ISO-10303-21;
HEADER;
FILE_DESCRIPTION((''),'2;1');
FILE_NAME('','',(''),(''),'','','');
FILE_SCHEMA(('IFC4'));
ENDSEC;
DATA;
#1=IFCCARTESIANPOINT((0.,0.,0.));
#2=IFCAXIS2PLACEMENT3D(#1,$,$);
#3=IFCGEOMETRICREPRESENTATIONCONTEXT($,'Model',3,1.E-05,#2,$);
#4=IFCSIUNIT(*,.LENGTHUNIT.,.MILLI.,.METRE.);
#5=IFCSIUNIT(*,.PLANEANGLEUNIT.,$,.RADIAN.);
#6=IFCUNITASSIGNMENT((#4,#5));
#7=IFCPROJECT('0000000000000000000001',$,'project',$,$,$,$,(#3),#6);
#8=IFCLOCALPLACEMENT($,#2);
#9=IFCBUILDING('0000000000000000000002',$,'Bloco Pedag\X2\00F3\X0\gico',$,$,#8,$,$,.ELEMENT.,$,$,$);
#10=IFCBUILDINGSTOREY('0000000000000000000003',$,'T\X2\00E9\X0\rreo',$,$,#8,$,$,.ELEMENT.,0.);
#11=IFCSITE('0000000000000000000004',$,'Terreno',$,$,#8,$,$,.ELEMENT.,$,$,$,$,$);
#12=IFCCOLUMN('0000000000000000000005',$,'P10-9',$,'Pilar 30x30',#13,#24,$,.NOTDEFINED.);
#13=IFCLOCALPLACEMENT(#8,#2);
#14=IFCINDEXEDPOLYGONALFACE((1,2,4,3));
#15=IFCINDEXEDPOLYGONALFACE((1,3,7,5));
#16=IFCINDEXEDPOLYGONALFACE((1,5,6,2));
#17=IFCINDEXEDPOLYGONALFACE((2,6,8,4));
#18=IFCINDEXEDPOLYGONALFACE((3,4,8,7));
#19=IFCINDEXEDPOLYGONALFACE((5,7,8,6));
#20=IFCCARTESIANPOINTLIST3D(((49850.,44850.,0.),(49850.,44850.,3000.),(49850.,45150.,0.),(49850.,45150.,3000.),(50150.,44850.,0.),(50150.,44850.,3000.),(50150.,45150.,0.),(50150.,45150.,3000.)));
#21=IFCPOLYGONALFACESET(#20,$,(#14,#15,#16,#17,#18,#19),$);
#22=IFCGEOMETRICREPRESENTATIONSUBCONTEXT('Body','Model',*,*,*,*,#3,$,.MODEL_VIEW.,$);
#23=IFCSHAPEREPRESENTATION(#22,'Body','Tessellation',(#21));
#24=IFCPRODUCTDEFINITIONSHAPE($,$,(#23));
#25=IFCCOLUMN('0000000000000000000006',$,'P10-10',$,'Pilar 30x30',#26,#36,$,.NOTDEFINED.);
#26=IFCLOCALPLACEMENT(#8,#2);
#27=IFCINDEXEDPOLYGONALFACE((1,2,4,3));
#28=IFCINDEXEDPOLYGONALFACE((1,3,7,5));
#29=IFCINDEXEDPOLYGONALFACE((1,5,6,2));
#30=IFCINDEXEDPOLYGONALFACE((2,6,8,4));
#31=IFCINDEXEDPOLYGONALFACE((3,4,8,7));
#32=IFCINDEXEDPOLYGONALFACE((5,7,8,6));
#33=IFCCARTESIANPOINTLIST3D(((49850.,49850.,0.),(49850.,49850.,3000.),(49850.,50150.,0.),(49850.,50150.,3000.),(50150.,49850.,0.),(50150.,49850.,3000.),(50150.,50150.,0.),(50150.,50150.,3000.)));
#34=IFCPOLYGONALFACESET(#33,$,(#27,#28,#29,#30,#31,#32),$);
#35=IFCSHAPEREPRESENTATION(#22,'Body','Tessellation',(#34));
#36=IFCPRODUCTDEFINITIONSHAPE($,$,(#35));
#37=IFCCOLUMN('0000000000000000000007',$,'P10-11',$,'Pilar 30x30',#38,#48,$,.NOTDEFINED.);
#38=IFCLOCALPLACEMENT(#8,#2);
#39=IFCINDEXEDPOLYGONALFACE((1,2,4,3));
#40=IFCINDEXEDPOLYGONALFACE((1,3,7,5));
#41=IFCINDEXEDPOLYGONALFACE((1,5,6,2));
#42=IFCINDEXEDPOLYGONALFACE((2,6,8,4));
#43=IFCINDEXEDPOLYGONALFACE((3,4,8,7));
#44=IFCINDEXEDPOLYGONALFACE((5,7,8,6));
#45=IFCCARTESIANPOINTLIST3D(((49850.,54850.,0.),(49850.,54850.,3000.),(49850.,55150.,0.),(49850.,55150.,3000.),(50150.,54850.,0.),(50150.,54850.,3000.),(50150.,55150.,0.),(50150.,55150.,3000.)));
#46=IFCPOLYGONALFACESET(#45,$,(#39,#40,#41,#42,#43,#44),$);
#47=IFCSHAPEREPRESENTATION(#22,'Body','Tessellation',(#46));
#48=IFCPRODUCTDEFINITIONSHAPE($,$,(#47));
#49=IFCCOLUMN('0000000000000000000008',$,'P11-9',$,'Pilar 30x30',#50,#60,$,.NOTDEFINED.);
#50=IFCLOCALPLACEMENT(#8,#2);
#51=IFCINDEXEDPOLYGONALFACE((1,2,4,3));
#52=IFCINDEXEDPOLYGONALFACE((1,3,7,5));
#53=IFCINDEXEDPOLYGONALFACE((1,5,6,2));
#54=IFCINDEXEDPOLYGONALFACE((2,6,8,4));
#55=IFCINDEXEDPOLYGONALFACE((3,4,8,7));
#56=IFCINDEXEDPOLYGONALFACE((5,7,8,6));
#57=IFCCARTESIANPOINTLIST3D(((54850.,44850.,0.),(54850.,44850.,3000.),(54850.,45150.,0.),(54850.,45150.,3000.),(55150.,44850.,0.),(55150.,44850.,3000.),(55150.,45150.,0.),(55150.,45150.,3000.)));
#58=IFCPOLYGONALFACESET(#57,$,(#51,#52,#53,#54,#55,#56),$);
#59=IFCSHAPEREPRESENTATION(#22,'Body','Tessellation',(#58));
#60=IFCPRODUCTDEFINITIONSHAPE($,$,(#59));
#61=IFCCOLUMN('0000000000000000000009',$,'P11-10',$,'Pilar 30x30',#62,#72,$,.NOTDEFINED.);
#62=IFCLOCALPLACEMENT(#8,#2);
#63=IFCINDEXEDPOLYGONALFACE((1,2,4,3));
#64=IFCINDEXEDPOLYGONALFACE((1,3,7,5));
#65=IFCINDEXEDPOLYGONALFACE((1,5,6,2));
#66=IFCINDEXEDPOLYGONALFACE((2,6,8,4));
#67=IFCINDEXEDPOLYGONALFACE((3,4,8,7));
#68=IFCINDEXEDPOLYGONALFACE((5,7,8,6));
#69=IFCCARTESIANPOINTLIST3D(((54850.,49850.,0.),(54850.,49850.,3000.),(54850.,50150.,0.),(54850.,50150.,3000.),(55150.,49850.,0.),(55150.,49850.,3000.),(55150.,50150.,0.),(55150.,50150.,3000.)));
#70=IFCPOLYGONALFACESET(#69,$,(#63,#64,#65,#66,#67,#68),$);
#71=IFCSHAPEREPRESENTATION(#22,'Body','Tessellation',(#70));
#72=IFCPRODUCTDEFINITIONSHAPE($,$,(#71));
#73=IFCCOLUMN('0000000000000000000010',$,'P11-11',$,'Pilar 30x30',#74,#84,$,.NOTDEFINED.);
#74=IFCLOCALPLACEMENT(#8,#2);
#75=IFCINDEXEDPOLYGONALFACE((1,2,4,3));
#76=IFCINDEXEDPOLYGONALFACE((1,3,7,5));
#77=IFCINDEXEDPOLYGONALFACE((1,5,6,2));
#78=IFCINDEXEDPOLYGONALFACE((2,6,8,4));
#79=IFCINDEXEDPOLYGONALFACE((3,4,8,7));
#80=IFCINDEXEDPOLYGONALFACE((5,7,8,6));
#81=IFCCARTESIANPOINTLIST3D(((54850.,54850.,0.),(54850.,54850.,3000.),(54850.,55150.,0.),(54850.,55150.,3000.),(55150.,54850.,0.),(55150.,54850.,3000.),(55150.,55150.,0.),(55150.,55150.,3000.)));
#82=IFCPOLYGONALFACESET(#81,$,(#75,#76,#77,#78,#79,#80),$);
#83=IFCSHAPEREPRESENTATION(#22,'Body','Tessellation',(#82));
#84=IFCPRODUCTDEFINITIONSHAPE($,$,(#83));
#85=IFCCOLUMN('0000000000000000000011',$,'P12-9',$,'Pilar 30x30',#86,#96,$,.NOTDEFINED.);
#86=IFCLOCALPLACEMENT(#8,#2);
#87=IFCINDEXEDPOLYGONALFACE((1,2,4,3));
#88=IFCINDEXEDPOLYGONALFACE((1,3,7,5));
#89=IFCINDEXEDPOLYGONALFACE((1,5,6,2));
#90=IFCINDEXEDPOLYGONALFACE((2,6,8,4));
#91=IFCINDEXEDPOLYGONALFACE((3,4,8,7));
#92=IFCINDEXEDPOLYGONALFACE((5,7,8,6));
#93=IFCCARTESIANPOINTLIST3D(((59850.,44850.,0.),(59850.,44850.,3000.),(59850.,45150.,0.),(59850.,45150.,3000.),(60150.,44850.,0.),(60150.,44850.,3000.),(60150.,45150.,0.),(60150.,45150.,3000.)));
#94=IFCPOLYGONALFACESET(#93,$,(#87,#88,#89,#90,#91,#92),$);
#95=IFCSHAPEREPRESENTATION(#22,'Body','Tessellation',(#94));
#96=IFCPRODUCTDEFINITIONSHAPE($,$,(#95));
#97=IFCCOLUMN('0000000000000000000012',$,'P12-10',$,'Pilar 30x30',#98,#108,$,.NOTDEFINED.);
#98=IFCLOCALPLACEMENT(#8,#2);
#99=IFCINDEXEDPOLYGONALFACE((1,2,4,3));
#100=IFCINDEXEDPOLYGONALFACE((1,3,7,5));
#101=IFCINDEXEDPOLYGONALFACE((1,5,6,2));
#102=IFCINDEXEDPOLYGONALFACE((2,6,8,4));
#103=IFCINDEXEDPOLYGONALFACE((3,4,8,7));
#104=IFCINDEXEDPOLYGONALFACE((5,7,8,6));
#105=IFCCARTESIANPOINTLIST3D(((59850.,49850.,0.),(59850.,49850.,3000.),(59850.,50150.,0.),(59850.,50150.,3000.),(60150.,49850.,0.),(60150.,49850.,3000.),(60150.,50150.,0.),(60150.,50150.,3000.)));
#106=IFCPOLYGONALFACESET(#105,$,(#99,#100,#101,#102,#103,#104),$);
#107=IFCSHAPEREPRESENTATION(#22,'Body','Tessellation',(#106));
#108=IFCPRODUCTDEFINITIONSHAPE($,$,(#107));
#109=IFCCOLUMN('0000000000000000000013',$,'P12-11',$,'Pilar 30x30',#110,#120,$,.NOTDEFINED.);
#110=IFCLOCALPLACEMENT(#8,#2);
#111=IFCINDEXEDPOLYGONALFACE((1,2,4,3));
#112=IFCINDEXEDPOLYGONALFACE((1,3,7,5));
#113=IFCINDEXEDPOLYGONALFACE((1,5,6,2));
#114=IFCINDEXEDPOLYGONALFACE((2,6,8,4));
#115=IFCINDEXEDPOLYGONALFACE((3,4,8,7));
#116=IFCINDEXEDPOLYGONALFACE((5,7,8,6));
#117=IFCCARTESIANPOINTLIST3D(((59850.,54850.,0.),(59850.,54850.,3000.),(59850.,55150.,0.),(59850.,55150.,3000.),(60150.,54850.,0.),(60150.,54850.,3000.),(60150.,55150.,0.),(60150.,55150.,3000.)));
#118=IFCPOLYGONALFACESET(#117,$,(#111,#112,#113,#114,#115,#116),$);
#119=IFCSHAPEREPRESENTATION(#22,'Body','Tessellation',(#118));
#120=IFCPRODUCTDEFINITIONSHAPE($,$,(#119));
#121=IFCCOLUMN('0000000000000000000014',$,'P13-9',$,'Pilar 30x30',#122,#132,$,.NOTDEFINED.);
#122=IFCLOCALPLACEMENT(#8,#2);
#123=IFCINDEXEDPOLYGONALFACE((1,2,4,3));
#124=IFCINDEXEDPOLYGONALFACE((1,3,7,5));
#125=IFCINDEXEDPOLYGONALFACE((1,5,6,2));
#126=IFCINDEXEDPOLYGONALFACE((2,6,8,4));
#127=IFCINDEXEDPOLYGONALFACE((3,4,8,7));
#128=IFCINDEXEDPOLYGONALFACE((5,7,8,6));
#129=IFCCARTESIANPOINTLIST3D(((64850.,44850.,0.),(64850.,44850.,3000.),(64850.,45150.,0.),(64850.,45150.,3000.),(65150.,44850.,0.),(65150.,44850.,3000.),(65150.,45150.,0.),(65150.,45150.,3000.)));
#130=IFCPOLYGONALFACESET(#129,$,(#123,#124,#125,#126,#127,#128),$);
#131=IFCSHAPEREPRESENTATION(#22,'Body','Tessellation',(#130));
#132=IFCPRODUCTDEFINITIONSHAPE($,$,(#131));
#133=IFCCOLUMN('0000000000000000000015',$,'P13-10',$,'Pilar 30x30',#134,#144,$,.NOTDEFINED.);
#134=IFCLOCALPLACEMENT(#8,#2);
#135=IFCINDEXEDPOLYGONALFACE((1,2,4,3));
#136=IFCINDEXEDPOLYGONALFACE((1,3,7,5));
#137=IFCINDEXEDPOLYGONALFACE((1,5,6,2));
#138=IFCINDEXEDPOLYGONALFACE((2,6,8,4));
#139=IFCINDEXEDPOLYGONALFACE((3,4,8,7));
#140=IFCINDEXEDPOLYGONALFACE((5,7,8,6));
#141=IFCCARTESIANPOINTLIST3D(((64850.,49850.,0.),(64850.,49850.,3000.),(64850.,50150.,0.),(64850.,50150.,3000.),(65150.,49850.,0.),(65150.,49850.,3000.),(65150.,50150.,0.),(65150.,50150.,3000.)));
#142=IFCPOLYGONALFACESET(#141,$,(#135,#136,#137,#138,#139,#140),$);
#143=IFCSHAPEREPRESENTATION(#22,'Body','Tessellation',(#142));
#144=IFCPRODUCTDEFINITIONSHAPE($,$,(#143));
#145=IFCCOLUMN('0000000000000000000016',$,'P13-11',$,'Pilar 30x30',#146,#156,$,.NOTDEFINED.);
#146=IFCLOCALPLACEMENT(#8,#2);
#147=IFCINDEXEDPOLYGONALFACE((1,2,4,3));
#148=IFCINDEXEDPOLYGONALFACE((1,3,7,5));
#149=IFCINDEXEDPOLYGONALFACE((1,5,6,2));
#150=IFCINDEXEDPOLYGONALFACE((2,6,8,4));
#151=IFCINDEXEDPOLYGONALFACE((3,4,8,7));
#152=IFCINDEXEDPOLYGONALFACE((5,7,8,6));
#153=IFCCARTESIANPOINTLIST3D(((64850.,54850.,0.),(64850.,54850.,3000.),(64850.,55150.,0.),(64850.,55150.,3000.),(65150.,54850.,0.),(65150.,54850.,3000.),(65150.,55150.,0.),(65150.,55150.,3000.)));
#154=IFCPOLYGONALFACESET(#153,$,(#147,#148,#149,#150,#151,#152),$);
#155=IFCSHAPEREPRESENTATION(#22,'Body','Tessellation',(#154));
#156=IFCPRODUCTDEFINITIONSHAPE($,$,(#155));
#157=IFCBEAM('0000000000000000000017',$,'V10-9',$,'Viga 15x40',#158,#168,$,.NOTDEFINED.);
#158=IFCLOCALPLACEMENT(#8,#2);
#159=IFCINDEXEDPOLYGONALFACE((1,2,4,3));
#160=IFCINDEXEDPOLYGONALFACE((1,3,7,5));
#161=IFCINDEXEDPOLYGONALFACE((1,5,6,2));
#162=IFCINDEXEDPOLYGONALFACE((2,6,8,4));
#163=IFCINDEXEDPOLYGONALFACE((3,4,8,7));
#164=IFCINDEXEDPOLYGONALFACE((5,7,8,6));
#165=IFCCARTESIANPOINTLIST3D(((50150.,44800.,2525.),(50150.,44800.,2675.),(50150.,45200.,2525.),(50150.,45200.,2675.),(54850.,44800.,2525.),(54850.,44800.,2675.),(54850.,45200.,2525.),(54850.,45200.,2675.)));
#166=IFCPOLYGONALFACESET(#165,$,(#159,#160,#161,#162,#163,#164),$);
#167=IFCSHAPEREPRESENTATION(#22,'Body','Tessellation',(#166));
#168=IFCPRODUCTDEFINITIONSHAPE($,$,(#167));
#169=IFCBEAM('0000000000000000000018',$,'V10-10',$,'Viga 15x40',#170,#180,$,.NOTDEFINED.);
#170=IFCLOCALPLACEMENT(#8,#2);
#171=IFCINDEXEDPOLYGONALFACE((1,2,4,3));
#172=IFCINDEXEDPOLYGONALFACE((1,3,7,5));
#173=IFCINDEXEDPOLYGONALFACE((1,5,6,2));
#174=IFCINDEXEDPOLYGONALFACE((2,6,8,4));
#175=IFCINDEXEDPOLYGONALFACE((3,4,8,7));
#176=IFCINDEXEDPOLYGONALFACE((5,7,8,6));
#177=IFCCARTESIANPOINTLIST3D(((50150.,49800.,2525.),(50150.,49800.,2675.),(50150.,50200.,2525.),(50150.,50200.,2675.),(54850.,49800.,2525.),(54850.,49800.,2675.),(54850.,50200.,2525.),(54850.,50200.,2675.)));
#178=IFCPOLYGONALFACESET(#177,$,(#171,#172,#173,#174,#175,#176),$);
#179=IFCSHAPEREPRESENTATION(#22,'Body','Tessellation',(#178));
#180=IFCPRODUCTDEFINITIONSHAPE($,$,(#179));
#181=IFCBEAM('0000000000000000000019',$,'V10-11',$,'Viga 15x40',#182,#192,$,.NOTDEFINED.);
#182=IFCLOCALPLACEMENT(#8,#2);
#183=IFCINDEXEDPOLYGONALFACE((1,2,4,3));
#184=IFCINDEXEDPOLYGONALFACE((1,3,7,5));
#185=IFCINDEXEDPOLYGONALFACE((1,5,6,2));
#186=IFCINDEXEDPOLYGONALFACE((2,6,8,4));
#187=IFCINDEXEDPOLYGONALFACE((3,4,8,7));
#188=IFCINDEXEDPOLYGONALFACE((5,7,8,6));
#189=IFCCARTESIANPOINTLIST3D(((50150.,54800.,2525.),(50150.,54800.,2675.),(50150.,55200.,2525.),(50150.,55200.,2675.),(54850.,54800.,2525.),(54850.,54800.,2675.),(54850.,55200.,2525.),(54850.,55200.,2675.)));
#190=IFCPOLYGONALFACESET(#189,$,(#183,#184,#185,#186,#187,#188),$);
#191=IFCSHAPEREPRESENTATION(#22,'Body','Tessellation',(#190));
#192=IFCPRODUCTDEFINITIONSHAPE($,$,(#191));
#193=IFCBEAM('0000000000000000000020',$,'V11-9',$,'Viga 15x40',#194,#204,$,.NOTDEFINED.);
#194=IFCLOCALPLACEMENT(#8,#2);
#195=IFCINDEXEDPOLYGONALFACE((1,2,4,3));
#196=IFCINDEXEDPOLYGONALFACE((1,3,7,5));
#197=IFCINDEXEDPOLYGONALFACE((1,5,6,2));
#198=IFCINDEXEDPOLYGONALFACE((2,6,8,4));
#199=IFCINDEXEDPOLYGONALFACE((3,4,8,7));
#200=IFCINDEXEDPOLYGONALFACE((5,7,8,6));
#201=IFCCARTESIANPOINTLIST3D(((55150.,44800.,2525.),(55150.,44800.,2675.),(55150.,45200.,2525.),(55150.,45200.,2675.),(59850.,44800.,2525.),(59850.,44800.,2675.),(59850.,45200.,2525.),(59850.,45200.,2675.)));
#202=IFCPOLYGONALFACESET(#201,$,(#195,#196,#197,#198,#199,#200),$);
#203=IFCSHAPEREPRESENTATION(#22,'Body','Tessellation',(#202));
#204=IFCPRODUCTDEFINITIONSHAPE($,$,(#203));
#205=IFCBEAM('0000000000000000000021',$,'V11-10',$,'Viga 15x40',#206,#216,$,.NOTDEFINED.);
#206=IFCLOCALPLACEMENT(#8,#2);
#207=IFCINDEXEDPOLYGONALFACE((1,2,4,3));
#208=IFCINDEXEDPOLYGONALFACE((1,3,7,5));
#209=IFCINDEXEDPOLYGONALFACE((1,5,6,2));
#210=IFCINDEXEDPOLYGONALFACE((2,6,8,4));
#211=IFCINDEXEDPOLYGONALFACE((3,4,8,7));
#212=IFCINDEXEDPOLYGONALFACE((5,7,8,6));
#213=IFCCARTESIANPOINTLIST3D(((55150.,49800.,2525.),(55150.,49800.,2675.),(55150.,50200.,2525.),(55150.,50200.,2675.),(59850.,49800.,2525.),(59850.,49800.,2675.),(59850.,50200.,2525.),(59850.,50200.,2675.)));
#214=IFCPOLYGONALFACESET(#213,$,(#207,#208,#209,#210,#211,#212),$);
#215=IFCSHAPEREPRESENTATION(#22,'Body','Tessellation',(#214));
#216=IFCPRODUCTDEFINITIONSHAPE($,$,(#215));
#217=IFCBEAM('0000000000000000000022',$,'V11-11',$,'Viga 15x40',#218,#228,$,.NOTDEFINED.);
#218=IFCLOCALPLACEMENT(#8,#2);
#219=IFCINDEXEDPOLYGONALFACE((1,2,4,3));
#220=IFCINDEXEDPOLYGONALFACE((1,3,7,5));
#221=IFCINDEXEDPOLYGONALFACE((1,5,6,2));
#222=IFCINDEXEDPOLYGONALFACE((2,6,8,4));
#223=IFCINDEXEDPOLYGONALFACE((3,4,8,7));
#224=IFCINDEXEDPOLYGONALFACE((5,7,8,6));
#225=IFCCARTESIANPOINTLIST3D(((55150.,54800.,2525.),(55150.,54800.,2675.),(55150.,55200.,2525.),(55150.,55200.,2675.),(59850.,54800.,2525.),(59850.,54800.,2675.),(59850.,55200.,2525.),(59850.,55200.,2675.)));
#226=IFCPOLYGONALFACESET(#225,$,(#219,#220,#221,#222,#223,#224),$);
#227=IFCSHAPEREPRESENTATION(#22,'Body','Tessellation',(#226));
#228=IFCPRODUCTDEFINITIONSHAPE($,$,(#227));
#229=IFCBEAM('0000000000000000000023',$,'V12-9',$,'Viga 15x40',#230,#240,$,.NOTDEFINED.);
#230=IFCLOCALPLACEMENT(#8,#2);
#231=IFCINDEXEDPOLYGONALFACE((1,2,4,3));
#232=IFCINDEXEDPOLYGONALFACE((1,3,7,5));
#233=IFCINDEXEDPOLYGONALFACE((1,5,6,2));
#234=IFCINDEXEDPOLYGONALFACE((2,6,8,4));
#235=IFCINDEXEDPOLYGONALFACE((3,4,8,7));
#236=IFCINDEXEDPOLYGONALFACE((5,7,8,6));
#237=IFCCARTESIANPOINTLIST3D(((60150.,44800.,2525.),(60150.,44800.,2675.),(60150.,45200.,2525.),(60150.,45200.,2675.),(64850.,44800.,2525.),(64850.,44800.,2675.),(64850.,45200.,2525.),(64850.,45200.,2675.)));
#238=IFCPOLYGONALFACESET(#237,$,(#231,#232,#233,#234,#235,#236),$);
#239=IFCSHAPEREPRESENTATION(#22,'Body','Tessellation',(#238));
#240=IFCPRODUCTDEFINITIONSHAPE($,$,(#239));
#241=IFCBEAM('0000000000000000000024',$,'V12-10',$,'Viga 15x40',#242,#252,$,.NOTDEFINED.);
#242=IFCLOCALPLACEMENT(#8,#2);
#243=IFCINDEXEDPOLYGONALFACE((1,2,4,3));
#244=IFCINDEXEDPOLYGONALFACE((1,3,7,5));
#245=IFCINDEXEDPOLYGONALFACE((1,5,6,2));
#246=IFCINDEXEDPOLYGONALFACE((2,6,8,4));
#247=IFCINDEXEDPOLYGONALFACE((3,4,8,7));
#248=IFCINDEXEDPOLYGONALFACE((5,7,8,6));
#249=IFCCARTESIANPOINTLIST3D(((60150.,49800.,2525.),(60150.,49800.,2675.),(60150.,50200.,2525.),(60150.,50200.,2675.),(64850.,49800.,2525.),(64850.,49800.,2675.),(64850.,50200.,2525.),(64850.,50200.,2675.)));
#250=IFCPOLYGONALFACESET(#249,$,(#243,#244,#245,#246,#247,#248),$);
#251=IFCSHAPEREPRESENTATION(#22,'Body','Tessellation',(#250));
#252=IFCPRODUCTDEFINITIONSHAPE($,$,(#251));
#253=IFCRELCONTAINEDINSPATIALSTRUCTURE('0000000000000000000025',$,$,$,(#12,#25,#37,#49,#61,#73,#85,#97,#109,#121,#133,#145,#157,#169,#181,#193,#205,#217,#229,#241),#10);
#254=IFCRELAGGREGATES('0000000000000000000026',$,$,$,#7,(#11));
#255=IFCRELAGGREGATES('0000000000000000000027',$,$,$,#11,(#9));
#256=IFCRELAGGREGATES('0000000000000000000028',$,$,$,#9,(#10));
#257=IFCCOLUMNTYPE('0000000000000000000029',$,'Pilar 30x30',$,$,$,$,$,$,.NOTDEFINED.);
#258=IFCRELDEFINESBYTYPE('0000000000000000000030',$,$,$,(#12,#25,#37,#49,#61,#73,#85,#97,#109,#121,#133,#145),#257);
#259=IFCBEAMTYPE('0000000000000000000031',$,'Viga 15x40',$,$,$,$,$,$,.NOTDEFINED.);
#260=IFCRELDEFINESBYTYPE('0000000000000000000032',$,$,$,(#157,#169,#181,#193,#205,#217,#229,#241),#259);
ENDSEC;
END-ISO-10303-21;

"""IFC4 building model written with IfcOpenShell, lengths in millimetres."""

from ifc_helpers import new_model, si_unit, frame, origin, origin_2d, place, context, subcontext, project, spatial, rectangle, extrude, type_object, element, save


model = new_model("IFC4")

# Units and contexts
model_context = context("Model", 3, precision=1e-05, world=origin())
body_context = subcontext(model_context, "Body", "Model", "MODEL_VIEW")
ifc_project = project(units=[si_unit("LENGTHUNIT", "METRE", prefix="MILLI"), si_unit("PLANEANGLEUNIT", "RADIAN")], contexts=[model_context])

# Site, building, storey
placement = place(None, origin())
site = spatial("IfcSite", under=ifc_project, at=placement, Name="Terreno", CompositionType="ELEMENT")
building = spatial("IfcBuilding", under=site, at=placement, Name="Bloco Pedagógico", CompositionType="ELEMENT")
storey = spatial("IfcBuildingStorey", under=building, at=placement, Name="Térreo", CompositionType="ELEMENT", Elevation=0.0)

# Columns
column_type = type_object("IfcColumnType", Name="Pilar 30x30", PredefinedType="NOTDEFINED")
for number, where, z_axis, x_axis, name in (
    (1, (50000.0, 45000.0, 0.0), (0.0, 0.0, 1.0), (1.0, 0.0, 0.0), "P10-9"),
    (2, (50000.0, 50000.0, 0.0), (0.0, 0.0, 1.0), (1.0, 0.0, 0.0), "P10-10"),
    (3, (50000.0, 55000.0, 0.0), (0.0, 0.0, 1.0), (1.0, 0.0, 0.0), "P10-11"),
    (4, (55000.0, 45000.0, 0.0), (0.0, 0.0, 1.0), (1.0, 0.0, 0.0), "P11-9"),
    (5, (55000.0, 50000.0, 0.0), (0.0, 0.0, 1.0), (1.0, 0.0, 0.0), "P11-10"),
    (6, (55000.0, 55000.0, 0.0), (0.0, 0.0, 1.0), (1.0, 0.0, 0.0), "P11-11"),
    (7, (60000.0, 45000.0, 0.0), (0.0, 0.0, 1.0), (1.0, 0.0, 0.0), "P12-9"),
    (8, (60000.0, 50000.0, 0.0), (0.0, 0.0, 1.0), (1.0, 0.0, 0.0), "P12-10"),
    (9, (60000.0, 55000.0, 0.0), (0.0, 0.0, 1.0), (1.0, 0.0, 0.0), "P12-11"),
    (10, (65000.0, 45000.0, 0.0), (0.0, 0.0, 1.0), (1.0, 0.0, 0.0), "P13-9"),
    (11, (65000.0, 50000.0, 0.0), (0.0, 0.0, 1.0), (1.0, 0.0, 0.0), "P13-10"),
    (12, (65000.0, 55000.0, 0.0), (0.0, 0.0, 1.0), (1.0, 0.0, 0.0), "P13-11"),
):
    element("IfcColumn", number, at=place(None, frame(where, z_axis=z_axis, x_axis=x_axis)), inside=storey, type_object=column_type, Name=name, ObjectType="Pilar 30x30", PredefinedType="NOTDEFINED", context=body_context, shape_type="SweptSolid", body=[
        extrude(rectangle(XDim=300.0, YDim=300.0, at=origin_2d()), None, (0.0, 0.0, 1.0), 3000.0),
    ])

# Beams
beam_type = type_object("IfcBeamType", Name="Viga 15x40", PredefinedType="NOTDEFINED")
for number, where, z_axis, x_axis, name in (
    (13, (50150.0, 45000.0, 2600.0), (1.0, 0.0, 0.0), (0.0, 1.0, 0.0), "V10-9"),
    (14, (50150.0, 50000.0, 2600.0), (1.0, 0.0, 0.0), (0.0, 1.0, 0.0), "V10-10"),
    (15, (50150.0, 55000.0, 2600.0), (1.0, 0.0, 0.0), (0.0, 1.0, 0.0), "V10-11"),
    (16, (55150.0, 45000.0, 2600.0), (1.0, 0.0, 0.0), (0.0, 1.0, 0.0), "V11-9"),
    (17, (55150.0, 50000.0, 2600.0), (1.0, 0.0, 0.0), (0.0, 1.0, 0.0), "V11-10"),
    (18, (55150.0, 55000.0, 2600.0), (1.0, 0.0, 0.0), (0.0, 1.0, 0.0), "V11-11"),
    (19, (60150.0, 45000.0, 2600.0), (1.0, 0.0, 0.0), (0.0, 1.0, 0.0), "V12-9"),
    (20, (60150.0, 50000.0, 2600.0), (1.0, 0.0, 0.0), (0.0, 1.0, 0.0), "V12-10"),
):
    element("IfcBeam", number, at=place(None, frame(where, z_axis=z_axis, x_axis=x_axis)), inside=storey, type_object=beam_type, Name=name, ObjectType="Viga 15x40", PredefinedType="NOTDEFINED", context=body_context, shape_type="SweptSolid", body=[
        extrude(rectangle(XDim=400.0, YDim=150.0, at=origin_2d()), None, (0.0, 0.0, 1.0), 4700.0),
    ])

save(model, "model.ifc")
